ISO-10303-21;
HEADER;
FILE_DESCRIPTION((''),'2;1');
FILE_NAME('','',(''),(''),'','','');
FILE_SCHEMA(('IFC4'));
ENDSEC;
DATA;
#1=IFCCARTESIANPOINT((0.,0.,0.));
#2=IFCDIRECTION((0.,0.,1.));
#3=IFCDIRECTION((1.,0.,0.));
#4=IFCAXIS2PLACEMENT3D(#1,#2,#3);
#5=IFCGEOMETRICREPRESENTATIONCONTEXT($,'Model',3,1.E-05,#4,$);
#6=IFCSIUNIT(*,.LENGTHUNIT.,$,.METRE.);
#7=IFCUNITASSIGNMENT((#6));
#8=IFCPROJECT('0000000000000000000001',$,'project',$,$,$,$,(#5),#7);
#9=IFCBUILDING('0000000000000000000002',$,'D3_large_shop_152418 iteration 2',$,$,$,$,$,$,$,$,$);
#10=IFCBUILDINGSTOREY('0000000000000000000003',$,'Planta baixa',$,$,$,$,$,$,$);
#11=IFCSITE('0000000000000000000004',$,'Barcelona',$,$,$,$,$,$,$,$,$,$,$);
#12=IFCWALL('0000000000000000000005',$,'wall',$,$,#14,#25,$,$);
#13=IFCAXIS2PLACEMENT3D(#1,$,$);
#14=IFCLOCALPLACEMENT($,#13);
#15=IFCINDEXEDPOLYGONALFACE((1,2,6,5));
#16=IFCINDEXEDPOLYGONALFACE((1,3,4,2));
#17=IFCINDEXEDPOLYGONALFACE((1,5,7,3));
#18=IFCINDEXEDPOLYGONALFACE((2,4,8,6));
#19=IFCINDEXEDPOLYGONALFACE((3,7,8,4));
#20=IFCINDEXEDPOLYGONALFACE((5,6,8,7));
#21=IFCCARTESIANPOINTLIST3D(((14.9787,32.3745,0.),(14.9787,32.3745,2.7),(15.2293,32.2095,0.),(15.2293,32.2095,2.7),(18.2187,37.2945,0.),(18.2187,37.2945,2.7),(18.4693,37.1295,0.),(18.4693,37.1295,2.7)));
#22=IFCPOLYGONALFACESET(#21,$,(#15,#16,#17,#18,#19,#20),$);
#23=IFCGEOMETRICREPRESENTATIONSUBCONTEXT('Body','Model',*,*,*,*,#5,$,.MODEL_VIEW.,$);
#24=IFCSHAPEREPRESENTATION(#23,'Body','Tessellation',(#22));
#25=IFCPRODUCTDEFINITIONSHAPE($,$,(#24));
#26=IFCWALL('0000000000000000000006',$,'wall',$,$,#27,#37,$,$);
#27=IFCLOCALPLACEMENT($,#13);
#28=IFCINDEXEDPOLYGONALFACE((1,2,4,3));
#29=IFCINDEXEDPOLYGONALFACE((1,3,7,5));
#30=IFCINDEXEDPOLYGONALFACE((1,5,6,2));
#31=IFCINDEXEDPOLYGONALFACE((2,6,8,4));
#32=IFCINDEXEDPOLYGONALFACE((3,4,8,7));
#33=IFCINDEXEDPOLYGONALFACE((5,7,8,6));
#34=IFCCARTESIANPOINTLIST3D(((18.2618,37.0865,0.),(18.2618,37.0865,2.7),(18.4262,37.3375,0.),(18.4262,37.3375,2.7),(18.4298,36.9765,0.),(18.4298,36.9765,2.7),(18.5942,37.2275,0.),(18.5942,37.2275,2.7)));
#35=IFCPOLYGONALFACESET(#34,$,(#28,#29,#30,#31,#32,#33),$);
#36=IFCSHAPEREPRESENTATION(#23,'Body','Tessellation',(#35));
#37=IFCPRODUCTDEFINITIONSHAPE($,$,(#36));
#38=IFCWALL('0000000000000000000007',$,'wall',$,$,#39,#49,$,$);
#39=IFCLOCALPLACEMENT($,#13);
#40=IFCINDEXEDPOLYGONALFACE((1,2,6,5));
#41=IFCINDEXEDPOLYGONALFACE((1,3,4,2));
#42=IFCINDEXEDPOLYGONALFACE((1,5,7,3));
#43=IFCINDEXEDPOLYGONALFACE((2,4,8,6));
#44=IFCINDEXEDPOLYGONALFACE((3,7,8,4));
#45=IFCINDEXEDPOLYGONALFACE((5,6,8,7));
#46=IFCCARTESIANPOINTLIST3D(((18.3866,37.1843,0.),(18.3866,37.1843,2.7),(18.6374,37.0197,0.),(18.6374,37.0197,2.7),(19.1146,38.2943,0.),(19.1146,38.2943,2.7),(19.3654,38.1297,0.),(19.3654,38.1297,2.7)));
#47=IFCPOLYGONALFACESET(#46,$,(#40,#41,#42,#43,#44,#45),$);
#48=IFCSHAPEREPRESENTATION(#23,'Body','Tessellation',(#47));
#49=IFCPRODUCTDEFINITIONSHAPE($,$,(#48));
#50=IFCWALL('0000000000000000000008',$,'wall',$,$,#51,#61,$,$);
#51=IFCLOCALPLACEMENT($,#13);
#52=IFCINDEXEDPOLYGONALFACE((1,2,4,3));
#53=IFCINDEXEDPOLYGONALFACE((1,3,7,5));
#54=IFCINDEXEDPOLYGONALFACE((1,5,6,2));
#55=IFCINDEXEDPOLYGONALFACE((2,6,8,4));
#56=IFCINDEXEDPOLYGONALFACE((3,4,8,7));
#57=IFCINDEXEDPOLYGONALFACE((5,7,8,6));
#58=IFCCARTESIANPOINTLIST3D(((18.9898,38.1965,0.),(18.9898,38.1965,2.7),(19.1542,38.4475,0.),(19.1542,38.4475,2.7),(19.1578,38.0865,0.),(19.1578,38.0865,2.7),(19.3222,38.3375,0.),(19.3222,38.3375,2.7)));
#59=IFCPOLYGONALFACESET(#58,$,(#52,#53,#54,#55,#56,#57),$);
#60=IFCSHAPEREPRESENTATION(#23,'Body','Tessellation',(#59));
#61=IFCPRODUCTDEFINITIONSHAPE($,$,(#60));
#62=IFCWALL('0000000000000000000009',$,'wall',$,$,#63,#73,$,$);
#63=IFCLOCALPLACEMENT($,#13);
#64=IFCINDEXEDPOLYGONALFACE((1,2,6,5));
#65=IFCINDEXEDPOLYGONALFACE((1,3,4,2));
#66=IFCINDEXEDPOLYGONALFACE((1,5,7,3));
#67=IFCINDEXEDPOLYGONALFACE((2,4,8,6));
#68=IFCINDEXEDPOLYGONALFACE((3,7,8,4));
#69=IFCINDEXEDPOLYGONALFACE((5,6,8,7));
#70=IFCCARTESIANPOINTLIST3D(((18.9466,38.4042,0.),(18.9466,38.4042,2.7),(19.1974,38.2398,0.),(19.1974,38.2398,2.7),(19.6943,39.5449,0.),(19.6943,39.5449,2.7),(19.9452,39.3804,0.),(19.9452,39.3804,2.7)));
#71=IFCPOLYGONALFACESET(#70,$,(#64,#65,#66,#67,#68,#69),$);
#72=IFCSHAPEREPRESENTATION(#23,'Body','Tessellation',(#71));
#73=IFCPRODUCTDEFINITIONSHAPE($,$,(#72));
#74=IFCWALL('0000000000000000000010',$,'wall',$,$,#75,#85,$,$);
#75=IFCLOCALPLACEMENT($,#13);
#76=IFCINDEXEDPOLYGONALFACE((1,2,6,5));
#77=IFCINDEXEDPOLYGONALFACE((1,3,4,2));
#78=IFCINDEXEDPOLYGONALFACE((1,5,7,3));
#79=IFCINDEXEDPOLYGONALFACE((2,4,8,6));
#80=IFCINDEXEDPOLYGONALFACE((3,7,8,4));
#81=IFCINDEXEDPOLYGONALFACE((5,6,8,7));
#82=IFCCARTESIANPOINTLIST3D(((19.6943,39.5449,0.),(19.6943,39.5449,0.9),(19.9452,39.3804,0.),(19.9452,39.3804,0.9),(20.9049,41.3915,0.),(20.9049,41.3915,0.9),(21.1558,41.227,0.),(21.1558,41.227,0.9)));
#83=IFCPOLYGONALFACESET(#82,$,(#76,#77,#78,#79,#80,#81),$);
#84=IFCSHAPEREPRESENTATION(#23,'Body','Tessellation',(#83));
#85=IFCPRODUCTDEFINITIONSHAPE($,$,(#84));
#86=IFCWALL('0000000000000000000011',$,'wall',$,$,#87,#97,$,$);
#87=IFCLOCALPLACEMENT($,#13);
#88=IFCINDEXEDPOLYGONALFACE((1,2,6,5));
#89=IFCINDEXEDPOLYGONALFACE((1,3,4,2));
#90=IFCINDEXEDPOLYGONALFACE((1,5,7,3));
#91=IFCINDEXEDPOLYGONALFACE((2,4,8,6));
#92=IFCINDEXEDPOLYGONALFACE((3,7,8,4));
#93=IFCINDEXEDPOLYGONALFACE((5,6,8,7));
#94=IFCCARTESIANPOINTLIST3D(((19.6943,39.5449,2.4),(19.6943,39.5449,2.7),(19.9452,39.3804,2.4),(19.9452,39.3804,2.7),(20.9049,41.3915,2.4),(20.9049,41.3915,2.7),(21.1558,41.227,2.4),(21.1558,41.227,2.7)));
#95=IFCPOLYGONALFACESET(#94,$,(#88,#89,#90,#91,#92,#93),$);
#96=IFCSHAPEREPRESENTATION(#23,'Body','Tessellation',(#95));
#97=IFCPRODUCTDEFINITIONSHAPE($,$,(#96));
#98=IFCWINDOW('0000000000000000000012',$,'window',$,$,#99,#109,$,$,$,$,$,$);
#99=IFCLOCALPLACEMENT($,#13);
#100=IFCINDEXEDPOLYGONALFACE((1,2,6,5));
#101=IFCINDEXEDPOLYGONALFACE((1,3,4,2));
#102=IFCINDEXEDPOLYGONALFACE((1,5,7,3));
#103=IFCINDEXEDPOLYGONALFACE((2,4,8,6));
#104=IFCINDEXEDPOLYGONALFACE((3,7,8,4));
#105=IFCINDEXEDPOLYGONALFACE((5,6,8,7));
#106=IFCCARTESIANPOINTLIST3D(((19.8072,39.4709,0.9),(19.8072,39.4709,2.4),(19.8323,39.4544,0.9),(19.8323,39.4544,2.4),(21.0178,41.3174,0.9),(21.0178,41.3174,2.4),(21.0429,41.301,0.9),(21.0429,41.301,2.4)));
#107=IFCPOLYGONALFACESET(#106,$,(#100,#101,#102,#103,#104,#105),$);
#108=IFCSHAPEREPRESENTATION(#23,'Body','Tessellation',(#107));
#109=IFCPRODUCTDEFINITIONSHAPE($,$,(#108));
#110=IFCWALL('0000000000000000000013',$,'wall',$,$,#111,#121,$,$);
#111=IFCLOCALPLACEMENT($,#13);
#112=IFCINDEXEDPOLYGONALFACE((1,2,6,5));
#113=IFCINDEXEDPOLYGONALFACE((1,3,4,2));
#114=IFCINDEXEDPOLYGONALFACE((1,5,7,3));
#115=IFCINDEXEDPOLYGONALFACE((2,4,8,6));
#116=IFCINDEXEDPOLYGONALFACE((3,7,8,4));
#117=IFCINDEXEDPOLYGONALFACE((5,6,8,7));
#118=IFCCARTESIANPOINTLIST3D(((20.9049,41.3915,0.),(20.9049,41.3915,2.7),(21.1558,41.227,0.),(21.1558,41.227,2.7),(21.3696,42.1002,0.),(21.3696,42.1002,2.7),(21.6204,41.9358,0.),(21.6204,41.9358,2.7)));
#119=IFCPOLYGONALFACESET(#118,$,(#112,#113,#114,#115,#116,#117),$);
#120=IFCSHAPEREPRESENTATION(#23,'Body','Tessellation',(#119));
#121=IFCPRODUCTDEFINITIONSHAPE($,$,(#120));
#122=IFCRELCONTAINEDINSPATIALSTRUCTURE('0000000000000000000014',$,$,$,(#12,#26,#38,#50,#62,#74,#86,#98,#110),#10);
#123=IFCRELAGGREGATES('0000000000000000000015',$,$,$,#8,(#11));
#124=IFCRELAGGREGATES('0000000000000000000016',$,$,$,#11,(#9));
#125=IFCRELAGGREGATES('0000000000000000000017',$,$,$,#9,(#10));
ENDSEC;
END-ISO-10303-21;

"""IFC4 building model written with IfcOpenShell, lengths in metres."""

from ifc_helpers import new_model, si_unit, frame, origin, origin_with_axes, place, context, subcontext, project, spatial, polyline, outline, extrude, element, save


model = new_model("IFC4")

# Units and contexts
model_context = context("Model", 3, precision=1e-05, world=origin_with_axes())
body_context = subcontext(model_context, "Body", "Model", "MODEL_VIEW")
ifc_project = project(units=[si_unit("LENGTHUNIT", "METRE")], contexts=[model_context])

# Site, building, storey
site = spatial("IfcSite", under=ifc_project, Name="Barcelona")
building = spatial("IfcBuilding", under=site, Name="D3_large_shop_152418 iteration 2")
storey = spatial("IfcBuildingStorey", under=building, Name="Planta baixa")

# Walls
wall_1_placement = place(None, origin_with_axes())
element("IfcWall", 1, at=wall_1_placement, inside=storey, Name="wall", context=body_context, shape_type="SweptSolid", body=[
    extrude(outline(polyline([(14.9787, 32.3745), (18.2187, 37.2945), (18.4693, 37.1295), (15.2293, 32.2095), (14.9787, 32.3745)])), origin(), (0.0, 0.0, 1.0), 2.7),
])
wall_2_placement = place(None, origin_with_axes())
element("IfcWall", 2, at=wall_2_placement, inside=storey, Name="wall", context=body_context, shape_type="SweptSolid", body=[
    extrude(outline(polyline([(18.4262, 37.3375), (18.5942, 37.2275), (18.4298, 36.9765), (18.2618, 37.0865), (18.4262, 37.3375)])), origin(), (0.0, 0.0, 1.0), 2.7),
])
wall_3_placement = place(None, origin_with_axes())
element("IfcWall", 3, at=wall_3_placement, inside=storey, Name="wall", context=body_context, shape_type="SweptSolid", body=[
    extrude(outline(polyline([(18.3866, 37.1843), (19.1146, 38.2943), (19.3654, 38.1297), (18.6374, 37.0197), (18.3866, 37.1843)])), origin(), (0.0, 0.0, 1.0), 2.7),
])
wall_4_placement = place(None, origin_with_axes())
element("IfcWall", 4, at=wall_4_placement, inside=storey, Name="wall", context=body_context, shape_type="SweptSolid", body=[
    extrude(outline(polyline([(19.1578, 38.0865), (18.9898, 38.1965), (19.1542, 38.4475), (19.3222, 38.3375), (19.1578, 38.0865)])), origin(), (0.0, 0.0, 1.0), 2.7),
])
wall_5_placement = place(None, origin_with_axes())
element("IfcWall", 5, at=wall_5_placement, inside=storey, Name="wall", context=body_context, shape_type="SweptSolid", body=[
    extrude(outline(polyline([(18.9466, 38.4042), (19.6943, 39.5449), (19.9452, 39.3804), (19.1974, 38.2398), (18.9466, 38.4042)])), origin(), (0.0, 0.0, 1.0), 2.7),
])
wall_6_placement = place(None, origin_with_axes())
element("IfcWall", 6, at=wall_6_placement, inside=storey, Name="wall", context=body_context, shape_type="SweptSolid", body=[
    extrude(outline(polyline([(19.6943, 39.5449), (20.9049, 41.3915), (21.1558, 41.227), (19.9452, 39.3804), (19.6943, 39.5449)])), origin(), (0.0, 0.0, 1.0), 0.9),
])
wall_7_placement = place(None, origin_with_axes())
element("IfcWall", 7, at=wall_7_placement, inside=storey, Name="wall", context=body_context, shape_type="SweptSolid", body=[
    extrude(outline(polyline([(19.6943, 39.5449), (20.9049, 41.3915), (21.1558, 41.227), (19.9452, 39.3804), (19.6943, 39.5449)])), frame((0.0, 0.0, 2.4)), (0.0, 0.0, 1.0), 0.3),
])

# Window
window_placement = place(None, origin_with_axes())
element("IfcWindow", 8, at=window_placement, inside=storey, Name="window", context=body_context, shape_type="SweptSolid", body=[
    extrude(outline(polyline([(19.8072, 39.4709), (21.0178, 41.3174), (21.0429, 41.301), (19.8323, 39.4544), (19.8072, 39.4709)])), frame((0.0, 0.0, 0.9)), (0.0, 0.0, 1.0), 1.5),
])

# Wall
wall_8_placement = place(None, origin_with_axes())
element("IfcWall", 9, at=wall_8_placement, inside=storey, Name="wall", context=body_context, shape_type="SweptSolid", body=[
    extrude(outline(polyline([(20.9049, 41.3915), (21.3696, 42.1002), (21.6204, 41.9358), (21.1558, 41.227), (20.9049, 41.3915)])), origin(), (0.0, 0.0, 1.0), 2.7),
])

save(model, "model.ifc")
